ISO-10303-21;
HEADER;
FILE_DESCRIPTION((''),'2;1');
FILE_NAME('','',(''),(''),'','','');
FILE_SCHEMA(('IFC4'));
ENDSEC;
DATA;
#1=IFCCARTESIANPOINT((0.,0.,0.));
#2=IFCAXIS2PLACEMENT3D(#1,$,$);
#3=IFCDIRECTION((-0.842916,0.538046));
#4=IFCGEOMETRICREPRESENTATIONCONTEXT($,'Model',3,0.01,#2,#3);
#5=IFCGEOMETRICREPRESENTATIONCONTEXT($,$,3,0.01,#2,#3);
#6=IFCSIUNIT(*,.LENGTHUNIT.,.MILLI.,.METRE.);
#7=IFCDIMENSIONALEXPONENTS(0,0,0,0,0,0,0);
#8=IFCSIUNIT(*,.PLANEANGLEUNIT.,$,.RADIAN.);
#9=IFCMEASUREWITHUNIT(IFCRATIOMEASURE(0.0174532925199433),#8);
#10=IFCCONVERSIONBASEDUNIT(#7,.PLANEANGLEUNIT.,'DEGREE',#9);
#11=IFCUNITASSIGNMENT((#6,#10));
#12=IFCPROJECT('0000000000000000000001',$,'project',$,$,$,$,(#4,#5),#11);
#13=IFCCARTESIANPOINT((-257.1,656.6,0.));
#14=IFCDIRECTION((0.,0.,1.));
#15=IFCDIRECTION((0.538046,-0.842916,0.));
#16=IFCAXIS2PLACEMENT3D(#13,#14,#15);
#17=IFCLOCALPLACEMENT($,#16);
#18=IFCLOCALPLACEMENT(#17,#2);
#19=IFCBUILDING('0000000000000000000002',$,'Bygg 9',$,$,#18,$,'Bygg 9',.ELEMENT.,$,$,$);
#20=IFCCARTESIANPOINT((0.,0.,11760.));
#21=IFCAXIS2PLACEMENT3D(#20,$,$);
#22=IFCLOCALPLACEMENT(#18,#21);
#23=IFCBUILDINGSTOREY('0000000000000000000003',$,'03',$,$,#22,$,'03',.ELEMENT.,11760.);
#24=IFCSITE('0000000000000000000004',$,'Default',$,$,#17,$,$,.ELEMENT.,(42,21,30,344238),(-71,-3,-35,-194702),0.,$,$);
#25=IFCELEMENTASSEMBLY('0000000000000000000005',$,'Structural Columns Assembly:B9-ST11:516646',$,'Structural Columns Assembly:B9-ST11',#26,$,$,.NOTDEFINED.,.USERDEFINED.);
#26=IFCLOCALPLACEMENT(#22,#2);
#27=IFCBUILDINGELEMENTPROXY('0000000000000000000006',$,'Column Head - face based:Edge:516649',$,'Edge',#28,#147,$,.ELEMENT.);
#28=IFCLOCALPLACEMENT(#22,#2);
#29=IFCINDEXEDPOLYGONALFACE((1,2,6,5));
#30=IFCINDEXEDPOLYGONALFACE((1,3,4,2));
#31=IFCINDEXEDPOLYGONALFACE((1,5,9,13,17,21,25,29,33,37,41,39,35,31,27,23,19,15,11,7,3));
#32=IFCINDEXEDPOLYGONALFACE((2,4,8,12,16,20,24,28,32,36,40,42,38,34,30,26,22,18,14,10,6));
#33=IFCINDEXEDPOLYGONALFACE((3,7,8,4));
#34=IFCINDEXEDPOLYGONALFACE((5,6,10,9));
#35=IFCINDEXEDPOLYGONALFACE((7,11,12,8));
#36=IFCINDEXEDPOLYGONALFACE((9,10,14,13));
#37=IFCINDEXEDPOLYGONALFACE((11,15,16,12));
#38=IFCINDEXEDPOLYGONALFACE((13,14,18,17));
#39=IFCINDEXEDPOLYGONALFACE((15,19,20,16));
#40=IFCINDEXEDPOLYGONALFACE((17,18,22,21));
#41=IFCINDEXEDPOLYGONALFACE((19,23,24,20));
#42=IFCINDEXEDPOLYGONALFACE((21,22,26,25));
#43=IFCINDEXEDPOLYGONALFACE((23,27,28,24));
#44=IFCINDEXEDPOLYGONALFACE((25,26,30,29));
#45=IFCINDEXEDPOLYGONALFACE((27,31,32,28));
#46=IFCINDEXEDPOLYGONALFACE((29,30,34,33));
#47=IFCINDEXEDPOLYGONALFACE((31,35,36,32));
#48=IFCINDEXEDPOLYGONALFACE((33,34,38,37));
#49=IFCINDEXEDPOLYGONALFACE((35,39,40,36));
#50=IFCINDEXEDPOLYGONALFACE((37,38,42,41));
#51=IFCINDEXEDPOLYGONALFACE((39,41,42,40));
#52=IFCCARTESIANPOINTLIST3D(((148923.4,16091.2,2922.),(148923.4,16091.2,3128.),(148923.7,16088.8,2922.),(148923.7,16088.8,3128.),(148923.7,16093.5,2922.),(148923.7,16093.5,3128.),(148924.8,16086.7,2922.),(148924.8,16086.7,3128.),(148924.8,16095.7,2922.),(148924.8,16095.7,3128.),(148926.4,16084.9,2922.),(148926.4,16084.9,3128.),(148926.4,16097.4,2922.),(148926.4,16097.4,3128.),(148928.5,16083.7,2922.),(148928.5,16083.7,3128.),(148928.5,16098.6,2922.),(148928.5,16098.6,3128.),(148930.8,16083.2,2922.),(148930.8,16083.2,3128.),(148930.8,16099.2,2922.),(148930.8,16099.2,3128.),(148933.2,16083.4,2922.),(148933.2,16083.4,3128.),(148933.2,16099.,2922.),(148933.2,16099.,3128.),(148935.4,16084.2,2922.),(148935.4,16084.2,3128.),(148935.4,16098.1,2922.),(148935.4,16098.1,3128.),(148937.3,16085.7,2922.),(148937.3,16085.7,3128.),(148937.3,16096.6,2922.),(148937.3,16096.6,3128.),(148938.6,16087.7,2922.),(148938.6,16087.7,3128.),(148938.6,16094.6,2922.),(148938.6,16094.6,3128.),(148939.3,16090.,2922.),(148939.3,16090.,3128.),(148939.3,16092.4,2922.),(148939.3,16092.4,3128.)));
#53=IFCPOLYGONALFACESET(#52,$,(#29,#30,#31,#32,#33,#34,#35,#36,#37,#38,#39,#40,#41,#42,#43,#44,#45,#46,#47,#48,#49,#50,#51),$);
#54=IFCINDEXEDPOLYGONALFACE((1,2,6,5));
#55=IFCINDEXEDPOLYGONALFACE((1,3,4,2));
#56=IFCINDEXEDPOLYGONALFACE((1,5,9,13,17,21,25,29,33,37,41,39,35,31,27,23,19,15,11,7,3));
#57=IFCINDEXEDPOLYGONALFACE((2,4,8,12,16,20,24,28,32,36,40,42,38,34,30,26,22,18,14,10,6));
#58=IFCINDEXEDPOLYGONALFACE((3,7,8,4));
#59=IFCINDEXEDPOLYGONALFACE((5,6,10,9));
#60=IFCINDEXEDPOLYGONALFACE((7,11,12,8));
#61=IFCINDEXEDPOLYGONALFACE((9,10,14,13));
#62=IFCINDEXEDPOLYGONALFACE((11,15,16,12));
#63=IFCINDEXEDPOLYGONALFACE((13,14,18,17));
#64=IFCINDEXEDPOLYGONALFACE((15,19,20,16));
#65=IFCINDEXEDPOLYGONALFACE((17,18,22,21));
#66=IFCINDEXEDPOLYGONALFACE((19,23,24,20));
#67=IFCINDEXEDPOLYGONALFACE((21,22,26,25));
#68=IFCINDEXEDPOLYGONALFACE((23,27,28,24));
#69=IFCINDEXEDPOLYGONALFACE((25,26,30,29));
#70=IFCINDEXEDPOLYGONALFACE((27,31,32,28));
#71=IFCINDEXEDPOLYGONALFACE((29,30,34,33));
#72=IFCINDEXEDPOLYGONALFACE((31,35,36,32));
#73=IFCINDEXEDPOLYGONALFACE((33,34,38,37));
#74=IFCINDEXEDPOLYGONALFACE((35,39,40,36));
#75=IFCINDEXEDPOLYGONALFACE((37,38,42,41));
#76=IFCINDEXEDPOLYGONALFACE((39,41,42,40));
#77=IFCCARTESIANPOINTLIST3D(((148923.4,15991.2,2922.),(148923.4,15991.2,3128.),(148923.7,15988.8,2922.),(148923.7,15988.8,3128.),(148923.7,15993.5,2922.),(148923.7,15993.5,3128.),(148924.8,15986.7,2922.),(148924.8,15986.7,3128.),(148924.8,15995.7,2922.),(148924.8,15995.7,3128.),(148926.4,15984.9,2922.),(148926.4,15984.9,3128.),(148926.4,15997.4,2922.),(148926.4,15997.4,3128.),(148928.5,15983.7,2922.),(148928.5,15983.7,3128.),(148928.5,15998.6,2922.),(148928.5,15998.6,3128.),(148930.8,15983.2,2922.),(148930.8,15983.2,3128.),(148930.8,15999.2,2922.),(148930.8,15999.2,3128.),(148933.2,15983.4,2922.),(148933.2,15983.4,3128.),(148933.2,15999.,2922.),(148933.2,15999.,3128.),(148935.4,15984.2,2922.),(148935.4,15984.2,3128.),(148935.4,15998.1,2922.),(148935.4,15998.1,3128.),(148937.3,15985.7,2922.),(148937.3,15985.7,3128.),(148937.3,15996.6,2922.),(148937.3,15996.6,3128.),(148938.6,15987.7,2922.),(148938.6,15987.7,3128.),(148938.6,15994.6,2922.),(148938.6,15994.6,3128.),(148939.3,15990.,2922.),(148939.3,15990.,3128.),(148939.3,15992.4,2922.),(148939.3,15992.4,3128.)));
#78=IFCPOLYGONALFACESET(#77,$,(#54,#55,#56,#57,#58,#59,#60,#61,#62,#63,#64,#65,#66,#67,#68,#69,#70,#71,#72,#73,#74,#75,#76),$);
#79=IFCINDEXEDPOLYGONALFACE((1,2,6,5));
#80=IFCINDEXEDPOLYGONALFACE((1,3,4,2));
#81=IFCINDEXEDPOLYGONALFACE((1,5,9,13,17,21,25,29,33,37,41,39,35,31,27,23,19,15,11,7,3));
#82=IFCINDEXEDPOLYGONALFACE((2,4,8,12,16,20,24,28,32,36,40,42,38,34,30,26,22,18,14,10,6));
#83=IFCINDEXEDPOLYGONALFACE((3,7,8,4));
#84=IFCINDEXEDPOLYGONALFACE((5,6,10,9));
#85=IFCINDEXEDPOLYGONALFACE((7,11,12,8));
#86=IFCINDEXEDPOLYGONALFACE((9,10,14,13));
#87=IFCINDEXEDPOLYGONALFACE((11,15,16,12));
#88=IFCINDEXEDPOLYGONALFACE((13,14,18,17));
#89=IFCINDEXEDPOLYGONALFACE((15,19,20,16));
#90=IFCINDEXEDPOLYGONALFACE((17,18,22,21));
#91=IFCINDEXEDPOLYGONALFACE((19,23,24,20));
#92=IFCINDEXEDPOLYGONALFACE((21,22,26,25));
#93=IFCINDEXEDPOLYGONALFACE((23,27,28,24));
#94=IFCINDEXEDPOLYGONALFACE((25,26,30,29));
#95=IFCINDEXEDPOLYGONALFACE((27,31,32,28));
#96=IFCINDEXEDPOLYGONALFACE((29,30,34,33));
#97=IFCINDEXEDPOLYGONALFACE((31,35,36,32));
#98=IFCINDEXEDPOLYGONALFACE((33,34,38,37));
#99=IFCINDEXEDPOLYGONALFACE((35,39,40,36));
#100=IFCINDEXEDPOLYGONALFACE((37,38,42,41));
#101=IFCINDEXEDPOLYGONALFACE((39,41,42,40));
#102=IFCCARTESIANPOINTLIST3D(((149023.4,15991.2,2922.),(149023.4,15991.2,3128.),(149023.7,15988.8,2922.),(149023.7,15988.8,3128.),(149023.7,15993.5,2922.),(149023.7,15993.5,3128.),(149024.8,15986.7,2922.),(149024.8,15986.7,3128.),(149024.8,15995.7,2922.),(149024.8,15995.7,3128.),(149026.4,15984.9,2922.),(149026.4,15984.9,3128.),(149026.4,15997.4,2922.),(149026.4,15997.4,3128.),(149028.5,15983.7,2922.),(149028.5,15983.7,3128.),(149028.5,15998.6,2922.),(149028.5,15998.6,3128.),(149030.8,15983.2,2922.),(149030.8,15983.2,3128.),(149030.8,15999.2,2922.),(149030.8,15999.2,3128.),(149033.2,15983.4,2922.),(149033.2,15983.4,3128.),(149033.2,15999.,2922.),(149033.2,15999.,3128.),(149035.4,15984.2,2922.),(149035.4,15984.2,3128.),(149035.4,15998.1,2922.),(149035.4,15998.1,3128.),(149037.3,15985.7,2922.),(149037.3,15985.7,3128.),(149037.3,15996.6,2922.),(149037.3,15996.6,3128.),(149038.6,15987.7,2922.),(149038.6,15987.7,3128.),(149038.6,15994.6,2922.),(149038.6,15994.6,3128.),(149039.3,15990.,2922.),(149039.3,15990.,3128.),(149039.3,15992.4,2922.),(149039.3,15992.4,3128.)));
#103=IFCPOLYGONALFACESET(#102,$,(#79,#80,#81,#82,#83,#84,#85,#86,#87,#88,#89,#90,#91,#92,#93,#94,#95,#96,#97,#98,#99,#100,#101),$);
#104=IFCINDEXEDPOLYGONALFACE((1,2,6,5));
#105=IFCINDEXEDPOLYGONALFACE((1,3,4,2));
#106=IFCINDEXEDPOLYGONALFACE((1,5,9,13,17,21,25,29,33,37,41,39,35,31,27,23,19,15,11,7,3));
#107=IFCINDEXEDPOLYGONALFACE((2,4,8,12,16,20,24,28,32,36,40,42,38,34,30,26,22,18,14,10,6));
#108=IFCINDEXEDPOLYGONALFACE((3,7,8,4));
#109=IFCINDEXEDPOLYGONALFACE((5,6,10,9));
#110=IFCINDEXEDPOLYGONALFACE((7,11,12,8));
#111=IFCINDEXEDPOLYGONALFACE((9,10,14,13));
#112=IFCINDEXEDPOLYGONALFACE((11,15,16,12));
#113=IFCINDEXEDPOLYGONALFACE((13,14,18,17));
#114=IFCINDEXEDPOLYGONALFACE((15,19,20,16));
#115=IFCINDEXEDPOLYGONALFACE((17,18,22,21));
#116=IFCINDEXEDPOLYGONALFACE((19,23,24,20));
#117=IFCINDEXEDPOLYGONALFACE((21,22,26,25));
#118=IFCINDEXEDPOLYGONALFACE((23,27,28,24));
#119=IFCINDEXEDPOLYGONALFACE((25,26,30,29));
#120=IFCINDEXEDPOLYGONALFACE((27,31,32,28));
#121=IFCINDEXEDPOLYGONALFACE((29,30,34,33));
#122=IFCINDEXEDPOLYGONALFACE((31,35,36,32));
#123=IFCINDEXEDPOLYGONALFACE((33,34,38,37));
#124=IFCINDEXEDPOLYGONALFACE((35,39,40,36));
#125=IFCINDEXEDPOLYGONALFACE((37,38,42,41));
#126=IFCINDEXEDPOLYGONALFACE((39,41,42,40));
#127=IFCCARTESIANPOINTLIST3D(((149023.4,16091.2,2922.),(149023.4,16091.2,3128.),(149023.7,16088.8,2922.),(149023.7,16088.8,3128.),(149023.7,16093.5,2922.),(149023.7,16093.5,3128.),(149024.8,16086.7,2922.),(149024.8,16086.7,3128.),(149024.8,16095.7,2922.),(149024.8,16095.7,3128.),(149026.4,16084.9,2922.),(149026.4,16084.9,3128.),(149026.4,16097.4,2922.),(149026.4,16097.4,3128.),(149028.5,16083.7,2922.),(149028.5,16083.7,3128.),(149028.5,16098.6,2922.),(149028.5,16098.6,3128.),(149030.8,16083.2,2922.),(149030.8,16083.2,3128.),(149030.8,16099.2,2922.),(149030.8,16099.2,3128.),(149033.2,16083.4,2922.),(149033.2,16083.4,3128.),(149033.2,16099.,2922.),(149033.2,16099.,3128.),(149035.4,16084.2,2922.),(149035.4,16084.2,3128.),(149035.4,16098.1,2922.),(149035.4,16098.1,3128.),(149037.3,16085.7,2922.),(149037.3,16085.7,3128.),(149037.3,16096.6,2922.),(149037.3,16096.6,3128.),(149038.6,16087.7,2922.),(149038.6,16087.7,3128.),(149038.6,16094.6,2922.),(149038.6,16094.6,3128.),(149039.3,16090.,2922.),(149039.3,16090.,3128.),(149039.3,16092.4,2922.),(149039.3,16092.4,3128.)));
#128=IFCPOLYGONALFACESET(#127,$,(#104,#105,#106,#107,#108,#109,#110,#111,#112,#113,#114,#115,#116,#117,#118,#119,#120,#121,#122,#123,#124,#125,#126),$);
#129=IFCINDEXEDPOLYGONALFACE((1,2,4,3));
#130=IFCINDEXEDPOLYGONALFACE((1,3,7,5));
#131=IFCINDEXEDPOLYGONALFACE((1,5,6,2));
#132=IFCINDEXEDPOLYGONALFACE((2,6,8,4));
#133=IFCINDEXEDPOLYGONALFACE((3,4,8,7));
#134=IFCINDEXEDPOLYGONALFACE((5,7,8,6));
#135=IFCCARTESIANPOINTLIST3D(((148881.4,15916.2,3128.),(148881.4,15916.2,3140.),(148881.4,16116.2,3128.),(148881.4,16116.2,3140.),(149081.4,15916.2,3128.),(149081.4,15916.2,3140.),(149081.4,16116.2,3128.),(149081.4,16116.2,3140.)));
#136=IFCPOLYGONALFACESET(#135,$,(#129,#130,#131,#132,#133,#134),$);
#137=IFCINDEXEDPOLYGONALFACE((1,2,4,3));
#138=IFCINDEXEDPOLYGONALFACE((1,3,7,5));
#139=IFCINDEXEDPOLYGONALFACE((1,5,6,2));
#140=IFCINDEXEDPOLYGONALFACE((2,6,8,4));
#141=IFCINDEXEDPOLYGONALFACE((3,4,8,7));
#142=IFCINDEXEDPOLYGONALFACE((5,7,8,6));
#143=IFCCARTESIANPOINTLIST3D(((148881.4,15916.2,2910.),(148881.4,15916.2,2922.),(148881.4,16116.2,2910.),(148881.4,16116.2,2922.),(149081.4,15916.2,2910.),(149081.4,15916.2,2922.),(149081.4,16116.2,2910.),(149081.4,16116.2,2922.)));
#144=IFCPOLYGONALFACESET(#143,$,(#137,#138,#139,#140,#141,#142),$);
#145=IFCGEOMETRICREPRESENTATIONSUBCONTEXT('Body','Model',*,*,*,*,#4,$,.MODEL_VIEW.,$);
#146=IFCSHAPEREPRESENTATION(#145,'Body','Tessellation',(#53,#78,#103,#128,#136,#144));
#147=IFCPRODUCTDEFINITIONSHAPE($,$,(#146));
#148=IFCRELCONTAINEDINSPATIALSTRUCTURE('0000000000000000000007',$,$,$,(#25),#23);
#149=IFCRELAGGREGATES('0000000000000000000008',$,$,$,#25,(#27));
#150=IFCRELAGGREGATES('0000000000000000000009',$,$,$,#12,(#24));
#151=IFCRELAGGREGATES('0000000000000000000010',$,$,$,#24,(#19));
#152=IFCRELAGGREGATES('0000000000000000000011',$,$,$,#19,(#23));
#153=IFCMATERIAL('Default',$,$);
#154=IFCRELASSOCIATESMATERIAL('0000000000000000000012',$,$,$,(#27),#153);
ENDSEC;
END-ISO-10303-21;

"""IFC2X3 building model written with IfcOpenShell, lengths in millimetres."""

from ifc_helpers import new_model, entity, si_unit, converted_unit, direction, frame, frame_2d, origin, origin_2d_with_axis, place, context, subcontext, project, spatial, rectangle, circle, extrude, source, transform, mapped, material, element, aggregate, save


model = new_model("IFC2X3")

# Units and contexts
model_context = context("Model", 3, precision=0.01, world=origin(), true_north=direction((-0.842916, 0.538046)))
context_of_model = context(None, 3, precision=0.01, world=origin(), true_north=direction((-0.842916, 0.538046)))
body_context = subcontext(model_context, "Body", "Model", "MODEL_VIEW")
ifc_project = project(units=[si_unit("LENGTHUNIT", "METRE", prefix="MILLI"), converted_unit("PLANEANGLEUNIT", "DEGREE", entity("IfcRatioMeasure", 0.0174532925199433), si_unit("PLANEANGLEUNIT", "RADIAN"), dimensions=[0, 0, 0, 0, 0, 0, 0])], contexts=[model_context, context_of_model])

# Site, building, storey
site_placement = place(None, frame((-257.1, 656.6, 0.0), z_axis=(0.0, 0.0, 1.0), x_axis=(0.538046, -0.842916, 0.0)))
site = spatial("IfcSite", under=ifc_project, at=site_placement, Name="Default", CompositionType="ELEMENT", RefLatitude=(42, 21, 30, 344238), RefLongitude=(-71, -3, -35, -194702), RefElevation=0.0)
building_placement = place(site_placement, origin())
building = spatial("IfcBuilding", under=site, at=building_placement, Name="Bygg 9", LongName="Bygg 9", CompositionType="ELEMENT")
storey_placement = place(building_placement, frame((0.0, 0.0, 11760.0)))
storey = spatial("IfcBuildingStorey", under=building, at=storey_placement, Name="03", LongName="03", CompositionType="ELEMENT", Elevation=11760.0)

# Element assembly
assembly_1_placement = place(storey_placement, origin())
assembly_1 = element("IfcElementAssembly", 1, at=assembly_1_placement, inside=storey, Name="Structural Columns Assembly:B9-ST11:516646", ObjectType="Structural Columns Assembly:B9-ST11", AssemblyPlace="NOTDEFINED", PredefinedType="USERDEFINED")

# Building element proxy
ifc_material_1 = material(Name="Default")
shared_shape_1 = source(origin(), body_context, "Body", "SweptSolid", [
    extrude(circle(Radius=8.0, at=frame_2d((0.0, 0.0), x_axis=(1.0, 0.0))), frame((50.0, -75.0, 12.0)), (0.0, 0.0, 1.0), 206.0),
    extrude(circle(Radius=8.0, at=frame_2d((0.0, 0.0), x_axis=(1.0, 0.0))), frame((50.0, 25.0, 12.0)), (0.0, 0.0, 1.0), 206.0),
    extrude(circle(Radius=8.0, at=frame_2d((0.0, 0.0), x_axis=(1.0, 0.0))), frame((-50.0, 25.0, 12.0)), (0.0, 0.0, 1.0), 206.0),
    extrude(circle(Radius=8.0, at=frame_2d((0.0, 0.0), x_axis=(1.0, 0.0))), frame((-50.0, -75.0, 12.0)), (0.0, 0.0, 1.0), 206.0),
    extrude(rectangle(XDim=200.0, YDim=200.0, at=origin_2d_with_axis()), frame((0.0, 0.0, 218.0), z_axis=(0.0, 0.0, 1.0), x_axis=(-1.0, 0.0, 0.0)), (0.0, 0.0, 1.0), 12.0),
    extrude(rectangle(XDim=200.0, YDim=200.0, at=origin_2d_with_axis()), frame((0.0, 0.0, 0.0), z_axis=(0.0, 0.0, 1.0), x_axis=(0.0, 1.0, 0.0)), (0.0, 0.0, 1.0), 12.0),
])
proxy_1_placement = place(assembly_1_placement, frame((148981.4, 16016.2, 2910.0), z_axis=(0.0, 0.0, 1.0), x_axis=(-1.0, 0.0, 0.0)))
proxy_1 = element("IfcBuildingElementProxy", 2, at=proxy_1_placement, material=ifc_material_1, Name="Column Head - face based:Edge:516649", ObjectType="Edge", CompositionType="ELEMENT", context=body_context, shape_type="MappedRepresentation", body=[
    mapped(shared_shape_1, transform((0.0, 0.0, 0.0), scale=1.0)),
])
aggregate(assembly_1, [proxy_1])

save(model, "model.ifc")
